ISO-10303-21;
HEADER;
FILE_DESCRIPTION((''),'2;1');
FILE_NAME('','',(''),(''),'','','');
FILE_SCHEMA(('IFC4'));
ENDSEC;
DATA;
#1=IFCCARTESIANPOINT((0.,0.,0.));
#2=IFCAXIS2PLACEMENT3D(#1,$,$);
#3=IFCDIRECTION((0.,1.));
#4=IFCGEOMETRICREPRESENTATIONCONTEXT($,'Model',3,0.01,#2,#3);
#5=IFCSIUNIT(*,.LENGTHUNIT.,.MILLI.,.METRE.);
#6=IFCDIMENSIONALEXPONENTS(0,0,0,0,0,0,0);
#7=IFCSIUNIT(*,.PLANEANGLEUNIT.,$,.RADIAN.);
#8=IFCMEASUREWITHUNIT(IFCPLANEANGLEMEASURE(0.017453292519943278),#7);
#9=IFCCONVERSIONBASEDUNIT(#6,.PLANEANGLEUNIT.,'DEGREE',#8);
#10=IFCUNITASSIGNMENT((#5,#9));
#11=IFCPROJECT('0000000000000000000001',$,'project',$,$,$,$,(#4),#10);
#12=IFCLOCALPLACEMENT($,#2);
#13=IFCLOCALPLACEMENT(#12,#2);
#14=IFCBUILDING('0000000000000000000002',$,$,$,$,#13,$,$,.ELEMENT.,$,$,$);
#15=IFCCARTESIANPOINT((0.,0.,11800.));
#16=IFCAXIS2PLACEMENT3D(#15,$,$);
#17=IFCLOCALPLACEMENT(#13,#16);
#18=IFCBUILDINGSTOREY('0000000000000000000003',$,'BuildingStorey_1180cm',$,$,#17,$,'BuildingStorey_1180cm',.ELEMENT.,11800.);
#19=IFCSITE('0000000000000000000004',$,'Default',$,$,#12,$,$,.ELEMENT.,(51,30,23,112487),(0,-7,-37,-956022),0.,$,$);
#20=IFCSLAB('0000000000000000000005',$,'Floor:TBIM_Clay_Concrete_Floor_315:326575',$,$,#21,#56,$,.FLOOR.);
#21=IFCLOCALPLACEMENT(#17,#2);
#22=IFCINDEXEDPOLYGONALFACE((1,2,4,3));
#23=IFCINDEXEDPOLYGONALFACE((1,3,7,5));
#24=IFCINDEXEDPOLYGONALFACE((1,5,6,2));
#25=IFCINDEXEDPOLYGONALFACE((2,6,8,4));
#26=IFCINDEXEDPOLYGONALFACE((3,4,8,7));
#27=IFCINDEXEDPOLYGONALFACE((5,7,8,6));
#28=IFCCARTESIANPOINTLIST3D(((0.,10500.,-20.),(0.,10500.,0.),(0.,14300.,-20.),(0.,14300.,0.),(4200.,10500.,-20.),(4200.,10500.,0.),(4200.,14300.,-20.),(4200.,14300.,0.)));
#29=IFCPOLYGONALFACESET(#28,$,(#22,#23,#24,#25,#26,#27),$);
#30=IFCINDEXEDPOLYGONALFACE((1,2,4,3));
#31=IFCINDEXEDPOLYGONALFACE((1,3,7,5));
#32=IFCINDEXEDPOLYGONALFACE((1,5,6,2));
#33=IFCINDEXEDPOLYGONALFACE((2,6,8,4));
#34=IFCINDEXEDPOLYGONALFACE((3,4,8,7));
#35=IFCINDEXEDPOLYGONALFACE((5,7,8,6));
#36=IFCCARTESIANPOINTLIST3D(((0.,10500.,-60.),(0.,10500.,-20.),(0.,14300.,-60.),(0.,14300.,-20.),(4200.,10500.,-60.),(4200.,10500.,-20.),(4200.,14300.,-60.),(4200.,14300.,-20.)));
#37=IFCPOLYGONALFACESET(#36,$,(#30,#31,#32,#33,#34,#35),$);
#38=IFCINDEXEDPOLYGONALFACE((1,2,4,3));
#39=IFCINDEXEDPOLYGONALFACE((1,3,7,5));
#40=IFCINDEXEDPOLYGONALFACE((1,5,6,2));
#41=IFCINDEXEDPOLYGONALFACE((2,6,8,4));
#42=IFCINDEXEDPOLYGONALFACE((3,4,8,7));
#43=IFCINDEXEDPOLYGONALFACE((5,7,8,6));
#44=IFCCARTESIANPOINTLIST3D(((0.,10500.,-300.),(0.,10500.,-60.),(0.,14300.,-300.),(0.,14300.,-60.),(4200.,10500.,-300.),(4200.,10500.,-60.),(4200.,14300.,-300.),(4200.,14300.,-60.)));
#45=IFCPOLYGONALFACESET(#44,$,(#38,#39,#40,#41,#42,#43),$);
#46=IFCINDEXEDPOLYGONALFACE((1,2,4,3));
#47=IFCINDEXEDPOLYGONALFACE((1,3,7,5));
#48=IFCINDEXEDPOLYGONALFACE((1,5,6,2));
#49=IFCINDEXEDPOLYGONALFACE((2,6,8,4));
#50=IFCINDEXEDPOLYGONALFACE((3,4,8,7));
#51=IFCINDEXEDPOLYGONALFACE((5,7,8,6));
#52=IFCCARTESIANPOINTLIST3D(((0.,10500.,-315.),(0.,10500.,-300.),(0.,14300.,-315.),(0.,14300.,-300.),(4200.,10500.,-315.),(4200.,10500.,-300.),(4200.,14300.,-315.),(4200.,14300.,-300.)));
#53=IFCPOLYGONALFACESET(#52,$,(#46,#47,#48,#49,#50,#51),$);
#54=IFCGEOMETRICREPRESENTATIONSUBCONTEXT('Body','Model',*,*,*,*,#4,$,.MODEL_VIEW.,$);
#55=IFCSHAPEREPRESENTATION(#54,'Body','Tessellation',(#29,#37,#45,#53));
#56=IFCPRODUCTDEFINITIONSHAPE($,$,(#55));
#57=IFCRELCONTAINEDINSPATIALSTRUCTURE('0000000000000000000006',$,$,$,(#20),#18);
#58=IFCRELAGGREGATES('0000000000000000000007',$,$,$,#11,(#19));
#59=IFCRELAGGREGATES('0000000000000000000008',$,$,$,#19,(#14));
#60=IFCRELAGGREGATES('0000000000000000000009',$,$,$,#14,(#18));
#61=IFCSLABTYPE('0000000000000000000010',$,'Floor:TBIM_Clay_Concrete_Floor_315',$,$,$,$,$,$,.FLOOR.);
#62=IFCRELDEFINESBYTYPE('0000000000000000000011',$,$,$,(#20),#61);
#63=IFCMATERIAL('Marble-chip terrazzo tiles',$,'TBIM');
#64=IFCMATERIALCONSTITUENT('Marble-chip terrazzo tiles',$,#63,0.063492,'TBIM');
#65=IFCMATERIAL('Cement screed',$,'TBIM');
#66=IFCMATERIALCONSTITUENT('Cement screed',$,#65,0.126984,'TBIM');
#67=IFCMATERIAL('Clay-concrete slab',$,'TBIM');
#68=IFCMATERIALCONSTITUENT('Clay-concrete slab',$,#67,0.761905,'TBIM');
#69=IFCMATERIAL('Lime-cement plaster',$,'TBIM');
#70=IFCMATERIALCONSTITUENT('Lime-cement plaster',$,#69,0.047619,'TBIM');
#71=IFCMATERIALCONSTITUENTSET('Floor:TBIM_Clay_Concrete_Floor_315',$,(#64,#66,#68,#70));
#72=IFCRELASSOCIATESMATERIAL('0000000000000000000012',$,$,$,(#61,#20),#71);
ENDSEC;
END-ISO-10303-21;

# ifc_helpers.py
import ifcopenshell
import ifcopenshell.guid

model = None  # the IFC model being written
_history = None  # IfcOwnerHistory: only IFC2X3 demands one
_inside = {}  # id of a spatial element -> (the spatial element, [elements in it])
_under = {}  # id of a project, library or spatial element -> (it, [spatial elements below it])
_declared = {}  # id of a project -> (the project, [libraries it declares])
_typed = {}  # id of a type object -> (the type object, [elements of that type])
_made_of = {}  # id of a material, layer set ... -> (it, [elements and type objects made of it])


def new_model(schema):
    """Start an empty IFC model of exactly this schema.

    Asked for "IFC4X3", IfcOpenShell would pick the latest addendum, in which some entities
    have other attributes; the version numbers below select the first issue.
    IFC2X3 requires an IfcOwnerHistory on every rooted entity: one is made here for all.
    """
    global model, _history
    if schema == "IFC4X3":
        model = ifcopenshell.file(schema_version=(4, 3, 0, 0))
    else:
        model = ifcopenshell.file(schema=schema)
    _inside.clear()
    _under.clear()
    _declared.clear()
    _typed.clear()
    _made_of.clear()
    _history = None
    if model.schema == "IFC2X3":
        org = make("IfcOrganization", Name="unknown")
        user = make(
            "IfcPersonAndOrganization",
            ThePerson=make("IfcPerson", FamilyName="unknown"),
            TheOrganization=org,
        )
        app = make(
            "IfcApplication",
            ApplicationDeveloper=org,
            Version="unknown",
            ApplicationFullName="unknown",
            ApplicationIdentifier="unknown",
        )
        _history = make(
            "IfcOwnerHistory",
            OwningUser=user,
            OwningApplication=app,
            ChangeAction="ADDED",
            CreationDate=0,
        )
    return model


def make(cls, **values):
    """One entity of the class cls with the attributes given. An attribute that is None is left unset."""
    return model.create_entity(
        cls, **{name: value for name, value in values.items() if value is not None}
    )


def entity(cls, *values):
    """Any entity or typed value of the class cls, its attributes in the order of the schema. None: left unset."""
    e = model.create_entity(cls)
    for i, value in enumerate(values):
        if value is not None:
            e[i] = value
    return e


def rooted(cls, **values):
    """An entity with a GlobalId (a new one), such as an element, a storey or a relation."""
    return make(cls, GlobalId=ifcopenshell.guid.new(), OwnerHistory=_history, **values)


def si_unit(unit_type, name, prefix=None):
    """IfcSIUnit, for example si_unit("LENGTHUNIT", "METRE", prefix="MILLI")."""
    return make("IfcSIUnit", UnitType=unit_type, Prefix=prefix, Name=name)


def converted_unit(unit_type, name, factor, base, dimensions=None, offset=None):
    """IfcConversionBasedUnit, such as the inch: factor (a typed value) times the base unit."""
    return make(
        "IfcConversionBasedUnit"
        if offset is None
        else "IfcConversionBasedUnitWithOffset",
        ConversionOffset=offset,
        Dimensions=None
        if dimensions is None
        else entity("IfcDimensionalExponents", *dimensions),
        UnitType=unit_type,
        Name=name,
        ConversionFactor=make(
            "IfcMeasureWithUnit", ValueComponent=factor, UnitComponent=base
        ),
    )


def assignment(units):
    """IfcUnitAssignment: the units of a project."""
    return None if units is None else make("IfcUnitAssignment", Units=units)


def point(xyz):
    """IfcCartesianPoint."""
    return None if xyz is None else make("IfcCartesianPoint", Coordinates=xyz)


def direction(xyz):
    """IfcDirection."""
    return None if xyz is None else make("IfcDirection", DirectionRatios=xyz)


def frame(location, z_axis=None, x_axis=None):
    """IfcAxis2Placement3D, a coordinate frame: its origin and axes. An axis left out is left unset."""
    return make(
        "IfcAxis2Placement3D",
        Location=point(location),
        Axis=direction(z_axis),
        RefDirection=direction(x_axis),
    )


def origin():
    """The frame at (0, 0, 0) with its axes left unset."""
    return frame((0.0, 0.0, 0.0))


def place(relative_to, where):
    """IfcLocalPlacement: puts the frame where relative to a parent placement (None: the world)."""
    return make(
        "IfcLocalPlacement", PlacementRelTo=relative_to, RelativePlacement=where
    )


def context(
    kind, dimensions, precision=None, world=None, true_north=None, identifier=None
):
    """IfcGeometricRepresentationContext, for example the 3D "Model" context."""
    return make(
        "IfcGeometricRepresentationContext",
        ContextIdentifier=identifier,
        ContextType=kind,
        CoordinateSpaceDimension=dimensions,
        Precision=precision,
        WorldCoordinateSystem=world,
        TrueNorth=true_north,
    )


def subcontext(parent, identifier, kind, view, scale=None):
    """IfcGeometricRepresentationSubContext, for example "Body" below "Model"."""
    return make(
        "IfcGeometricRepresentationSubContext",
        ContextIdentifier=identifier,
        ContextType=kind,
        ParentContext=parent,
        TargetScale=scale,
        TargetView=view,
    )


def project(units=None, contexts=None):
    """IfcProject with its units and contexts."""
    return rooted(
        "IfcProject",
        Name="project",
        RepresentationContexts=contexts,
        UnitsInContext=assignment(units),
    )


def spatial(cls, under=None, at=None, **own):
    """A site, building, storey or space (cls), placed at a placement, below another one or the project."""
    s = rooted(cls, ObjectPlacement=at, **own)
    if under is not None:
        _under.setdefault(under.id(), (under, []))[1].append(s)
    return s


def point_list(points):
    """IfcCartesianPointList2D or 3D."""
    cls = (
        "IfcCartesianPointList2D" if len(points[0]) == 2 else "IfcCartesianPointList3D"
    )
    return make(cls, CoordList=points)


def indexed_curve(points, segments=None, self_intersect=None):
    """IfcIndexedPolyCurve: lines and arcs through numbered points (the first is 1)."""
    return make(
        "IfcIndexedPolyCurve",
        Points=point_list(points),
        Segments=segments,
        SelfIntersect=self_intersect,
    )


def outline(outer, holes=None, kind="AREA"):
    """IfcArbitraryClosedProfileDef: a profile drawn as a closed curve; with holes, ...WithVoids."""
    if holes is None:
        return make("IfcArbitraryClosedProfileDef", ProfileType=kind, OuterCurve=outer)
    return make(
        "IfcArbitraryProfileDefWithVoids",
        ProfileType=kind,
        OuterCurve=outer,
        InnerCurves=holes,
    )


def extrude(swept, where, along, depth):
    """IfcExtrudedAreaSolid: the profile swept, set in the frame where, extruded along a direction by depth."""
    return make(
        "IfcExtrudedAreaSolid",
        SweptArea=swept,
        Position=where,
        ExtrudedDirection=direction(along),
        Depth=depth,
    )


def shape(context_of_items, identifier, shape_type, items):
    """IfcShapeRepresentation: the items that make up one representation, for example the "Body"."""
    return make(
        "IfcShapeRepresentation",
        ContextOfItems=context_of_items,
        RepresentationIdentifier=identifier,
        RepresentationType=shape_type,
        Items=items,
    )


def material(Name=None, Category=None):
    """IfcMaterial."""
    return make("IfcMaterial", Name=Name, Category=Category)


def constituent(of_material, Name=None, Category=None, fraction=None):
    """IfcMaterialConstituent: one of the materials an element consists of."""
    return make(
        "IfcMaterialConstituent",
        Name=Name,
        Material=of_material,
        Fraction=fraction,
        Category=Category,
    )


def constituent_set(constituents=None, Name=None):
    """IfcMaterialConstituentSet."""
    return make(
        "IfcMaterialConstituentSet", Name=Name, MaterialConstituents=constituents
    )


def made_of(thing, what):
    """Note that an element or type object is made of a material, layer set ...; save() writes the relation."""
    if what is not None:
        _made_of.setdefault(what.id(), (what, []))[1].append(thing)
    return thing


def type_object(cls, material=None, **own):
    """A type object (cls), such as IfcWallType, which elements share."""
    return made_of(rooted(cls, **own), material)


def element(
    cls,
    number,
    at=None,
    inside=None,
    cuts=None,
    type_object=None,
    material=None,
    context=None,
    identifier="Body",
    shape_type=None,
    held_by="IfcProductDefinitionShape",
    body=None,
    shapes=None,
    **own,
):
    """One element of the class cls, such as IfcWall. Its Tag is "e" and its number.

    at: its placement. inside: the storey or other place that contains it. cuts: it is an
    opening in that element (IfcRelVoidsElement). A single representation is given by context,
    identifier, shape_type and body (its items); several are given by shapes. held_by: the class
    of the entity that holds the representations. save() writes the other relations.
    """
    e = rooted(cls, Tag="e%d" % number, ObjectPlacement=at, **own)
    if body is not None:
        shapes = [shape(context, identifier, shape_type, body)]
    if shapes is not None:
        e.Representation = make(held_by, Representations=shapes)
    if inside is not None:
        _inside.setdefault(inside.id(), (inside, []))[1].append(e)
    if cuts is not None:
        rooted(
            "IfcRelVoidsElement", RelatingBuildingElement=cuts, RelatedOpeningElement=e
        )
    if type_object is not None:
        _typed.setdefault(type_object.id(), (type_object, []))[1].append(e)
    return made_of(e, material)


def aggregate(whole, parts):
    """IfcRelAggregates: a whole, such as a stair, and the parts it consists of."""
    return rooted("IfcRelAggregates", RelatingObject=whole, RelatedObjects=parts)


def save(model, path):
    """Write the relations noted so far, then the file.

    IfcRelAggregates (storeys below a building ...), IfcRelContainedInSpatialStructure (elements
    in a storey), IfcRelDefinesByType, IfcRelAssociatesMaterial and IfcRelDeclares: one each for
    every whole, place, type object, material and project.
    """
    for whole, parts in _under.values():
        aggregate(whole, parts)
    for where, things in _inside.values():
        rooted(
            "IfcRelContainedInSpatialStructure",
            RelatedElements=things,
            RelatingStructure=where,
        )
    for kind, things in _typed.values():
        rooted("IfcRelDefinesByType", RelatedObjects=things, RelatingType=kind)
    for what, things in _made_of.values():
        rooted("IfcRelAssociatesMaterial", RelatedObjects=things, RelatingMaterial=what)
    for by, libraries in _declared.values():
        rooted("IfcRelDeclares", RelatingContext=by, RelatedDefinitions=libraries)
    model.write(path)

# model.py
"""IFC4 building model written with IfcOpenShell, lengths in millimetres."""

from ifc_helpers import new_model, entity, si_unit, converted_unit, direction, frame, origin, place, context, subcontext, project, spatial, indexed_curve, outline, extrude, material, constituent, constituent_set, type_object, element, save


model = new_model("IFC4")

# Units and contexts
model_context = context("Model", 3, precision=0.01, world=origin(), true_north=direction((0.0, 1.0)))
body_context = subcontext(model_context, "Body", "Model", "MODEL_VIEW")
ifc_project = project(units=[si_unit("LENGTHUNIT", "METRE", prefix="MILLI"), converted_unit("PLANEANGLEUNIT", "DEGREE", entity("IfcPlaneAngleMeasure", 0.017453292519943278), si_unit("PLANEANGLEUNIT", "RADIAN"), dimensions=[0, 0, 0, 0, 0, 0, 0])], contexts=[model_context])

# Site, building, storey
site_placement = place(None, origin())
site = spatial("IfcSite", under=ifc_project, at=site_placement, Name="Default", CompositionType="ELEMENT", RefLatitude=(51, 30, 23, 112487), RefLongitude=(0, -7, -37, -956022), RefElevation=0.0)
building_placement = place(site_placement, origin())
building = spatial("IfcBuilding", under=site, at=building_placement, CompositionType="ELEMENT")
storey_placement = place(building_placement, frame((0.0, 0.0, 11800.0)))
storey = spatial("IfcBuildingStorey", under=building, at=storey_placement, Name="BuildingStorey_1180cm", LongName="BuildingStorey_1180cm", CompositionType="ELEMENT", Elevation=11800.0)

# Slab
ifc_material_1 = material(Name="Marble-chip terrazzo tiles", Category="TBIM")
ifc_constituent_1 = constituent(ifc_material_1, Name="Marble-chip terrazzo tiles", Category="TBIM", fraction=0.063492)
ifc_material_2 = material(Name="Cement screed", Category="TBIM")
ifc_constituent_2 = constituent(ifc_material_2, Name="Cement screed", Category="TBIM", fraction=0.126984)
ifc_material_3 = material(Name="Clay-concrete slab", Category="TBIM")
ifc_constituent_3 = constituent(ifc_material_3, Name="Clay-concrete slab", Category="TBIM", fraction=0.761905)
ifc_material_4 = material(Name="Lime-cement plaster", Category="TBIM")
ifc_constituent_4 = constituent(ifc_material_4, Name="Lime-cement plaster", Category="TBIM", fraction=0.047619)
ifc_constituent_set_1 = constituent_set(constituents=[ifc_constituent_1, ifc_constituent_2, ifc_constituent_3, ifc_constituent_4], Name="Floor:TBIM_Clay_Concrete_Floor_315")
slab_type = type_object("IfcSlabType", Name="Floor:TBIM_Clay_Concrete_Floor_315", PredefinedType="FLOOR", material=ifc_constituent_set_1)
slab_1_placement = place(storey_placement, origin())
element("IfcSlab", 1, at=slab_1_placement, inside=storey, type_object=slab_type, material=ifc_constituent_set_1, Name="Floor:TBIM_Clay_Concrete_Floor_315:326575", PredefinedType="FLOOR", context=body_context, shape_type="SweptSolid", body=[
    extrude(outline(indexed_curve([(-2100.0, -1900.0), (2100.0, -1900.0), (2100.0, 1900.0), (-2100.0, 1900.0), (-2100.0, -1900.0)], self_intersect=False)), frame((2100.0, 12400.0, -20.0), z_axis=(0.0, 0.0, 1.0), x_axis=(-1.0, 0.0, 0.0)), (0.0, 0.0, 1.0), 20.0),
    extrude(outline(indexed_curve([(-2100.0, -1900.0), (2100.0, -1900.0), (2100.0, 1900.0), (-2100.0, 1900.0), (-2100.0, -1900.0)], self_intersect=False)), frame((2100.0, 12400.0, -60.0), z_axis=(0.0, 0.0, 1.0), x_axis=(-1.0, 0.0, 0.0)), (0.0, 0.0, 1.0), 40.0),
    extrude(outline(indexed_curve([(-2100.0, -1900.0), (2100.0, -1900.0), (2100.0, 1900.0), (-2100.0, 1900.0), (-2100.0, -1900.0)], self_intersect=False)), frame((2100.0, 12400.0, -300.0), z_axis=(0.0, 0.0, 1.0), x_axis=(-1.0, 0.0, 0.0)), (0.0, 0.0, 1.0), 240.0),
    extrude(outline(indexed_curve([(-2100.0, -1900.0), (2100.0, -1900.0), (2100.0, 1900.0), (-2100.0, 1900.0), (-2100.0, -1900.0)], self_intersect=False)), frame((2100.0, 12400.0, -315.0), z_axis=(0.0, 0.0, 1.0), x_axis=(-1.0, 0.0, 0.0)), (0.0, 0.0, 1.0), 15.0),
])

save(model, "model.ifc")
